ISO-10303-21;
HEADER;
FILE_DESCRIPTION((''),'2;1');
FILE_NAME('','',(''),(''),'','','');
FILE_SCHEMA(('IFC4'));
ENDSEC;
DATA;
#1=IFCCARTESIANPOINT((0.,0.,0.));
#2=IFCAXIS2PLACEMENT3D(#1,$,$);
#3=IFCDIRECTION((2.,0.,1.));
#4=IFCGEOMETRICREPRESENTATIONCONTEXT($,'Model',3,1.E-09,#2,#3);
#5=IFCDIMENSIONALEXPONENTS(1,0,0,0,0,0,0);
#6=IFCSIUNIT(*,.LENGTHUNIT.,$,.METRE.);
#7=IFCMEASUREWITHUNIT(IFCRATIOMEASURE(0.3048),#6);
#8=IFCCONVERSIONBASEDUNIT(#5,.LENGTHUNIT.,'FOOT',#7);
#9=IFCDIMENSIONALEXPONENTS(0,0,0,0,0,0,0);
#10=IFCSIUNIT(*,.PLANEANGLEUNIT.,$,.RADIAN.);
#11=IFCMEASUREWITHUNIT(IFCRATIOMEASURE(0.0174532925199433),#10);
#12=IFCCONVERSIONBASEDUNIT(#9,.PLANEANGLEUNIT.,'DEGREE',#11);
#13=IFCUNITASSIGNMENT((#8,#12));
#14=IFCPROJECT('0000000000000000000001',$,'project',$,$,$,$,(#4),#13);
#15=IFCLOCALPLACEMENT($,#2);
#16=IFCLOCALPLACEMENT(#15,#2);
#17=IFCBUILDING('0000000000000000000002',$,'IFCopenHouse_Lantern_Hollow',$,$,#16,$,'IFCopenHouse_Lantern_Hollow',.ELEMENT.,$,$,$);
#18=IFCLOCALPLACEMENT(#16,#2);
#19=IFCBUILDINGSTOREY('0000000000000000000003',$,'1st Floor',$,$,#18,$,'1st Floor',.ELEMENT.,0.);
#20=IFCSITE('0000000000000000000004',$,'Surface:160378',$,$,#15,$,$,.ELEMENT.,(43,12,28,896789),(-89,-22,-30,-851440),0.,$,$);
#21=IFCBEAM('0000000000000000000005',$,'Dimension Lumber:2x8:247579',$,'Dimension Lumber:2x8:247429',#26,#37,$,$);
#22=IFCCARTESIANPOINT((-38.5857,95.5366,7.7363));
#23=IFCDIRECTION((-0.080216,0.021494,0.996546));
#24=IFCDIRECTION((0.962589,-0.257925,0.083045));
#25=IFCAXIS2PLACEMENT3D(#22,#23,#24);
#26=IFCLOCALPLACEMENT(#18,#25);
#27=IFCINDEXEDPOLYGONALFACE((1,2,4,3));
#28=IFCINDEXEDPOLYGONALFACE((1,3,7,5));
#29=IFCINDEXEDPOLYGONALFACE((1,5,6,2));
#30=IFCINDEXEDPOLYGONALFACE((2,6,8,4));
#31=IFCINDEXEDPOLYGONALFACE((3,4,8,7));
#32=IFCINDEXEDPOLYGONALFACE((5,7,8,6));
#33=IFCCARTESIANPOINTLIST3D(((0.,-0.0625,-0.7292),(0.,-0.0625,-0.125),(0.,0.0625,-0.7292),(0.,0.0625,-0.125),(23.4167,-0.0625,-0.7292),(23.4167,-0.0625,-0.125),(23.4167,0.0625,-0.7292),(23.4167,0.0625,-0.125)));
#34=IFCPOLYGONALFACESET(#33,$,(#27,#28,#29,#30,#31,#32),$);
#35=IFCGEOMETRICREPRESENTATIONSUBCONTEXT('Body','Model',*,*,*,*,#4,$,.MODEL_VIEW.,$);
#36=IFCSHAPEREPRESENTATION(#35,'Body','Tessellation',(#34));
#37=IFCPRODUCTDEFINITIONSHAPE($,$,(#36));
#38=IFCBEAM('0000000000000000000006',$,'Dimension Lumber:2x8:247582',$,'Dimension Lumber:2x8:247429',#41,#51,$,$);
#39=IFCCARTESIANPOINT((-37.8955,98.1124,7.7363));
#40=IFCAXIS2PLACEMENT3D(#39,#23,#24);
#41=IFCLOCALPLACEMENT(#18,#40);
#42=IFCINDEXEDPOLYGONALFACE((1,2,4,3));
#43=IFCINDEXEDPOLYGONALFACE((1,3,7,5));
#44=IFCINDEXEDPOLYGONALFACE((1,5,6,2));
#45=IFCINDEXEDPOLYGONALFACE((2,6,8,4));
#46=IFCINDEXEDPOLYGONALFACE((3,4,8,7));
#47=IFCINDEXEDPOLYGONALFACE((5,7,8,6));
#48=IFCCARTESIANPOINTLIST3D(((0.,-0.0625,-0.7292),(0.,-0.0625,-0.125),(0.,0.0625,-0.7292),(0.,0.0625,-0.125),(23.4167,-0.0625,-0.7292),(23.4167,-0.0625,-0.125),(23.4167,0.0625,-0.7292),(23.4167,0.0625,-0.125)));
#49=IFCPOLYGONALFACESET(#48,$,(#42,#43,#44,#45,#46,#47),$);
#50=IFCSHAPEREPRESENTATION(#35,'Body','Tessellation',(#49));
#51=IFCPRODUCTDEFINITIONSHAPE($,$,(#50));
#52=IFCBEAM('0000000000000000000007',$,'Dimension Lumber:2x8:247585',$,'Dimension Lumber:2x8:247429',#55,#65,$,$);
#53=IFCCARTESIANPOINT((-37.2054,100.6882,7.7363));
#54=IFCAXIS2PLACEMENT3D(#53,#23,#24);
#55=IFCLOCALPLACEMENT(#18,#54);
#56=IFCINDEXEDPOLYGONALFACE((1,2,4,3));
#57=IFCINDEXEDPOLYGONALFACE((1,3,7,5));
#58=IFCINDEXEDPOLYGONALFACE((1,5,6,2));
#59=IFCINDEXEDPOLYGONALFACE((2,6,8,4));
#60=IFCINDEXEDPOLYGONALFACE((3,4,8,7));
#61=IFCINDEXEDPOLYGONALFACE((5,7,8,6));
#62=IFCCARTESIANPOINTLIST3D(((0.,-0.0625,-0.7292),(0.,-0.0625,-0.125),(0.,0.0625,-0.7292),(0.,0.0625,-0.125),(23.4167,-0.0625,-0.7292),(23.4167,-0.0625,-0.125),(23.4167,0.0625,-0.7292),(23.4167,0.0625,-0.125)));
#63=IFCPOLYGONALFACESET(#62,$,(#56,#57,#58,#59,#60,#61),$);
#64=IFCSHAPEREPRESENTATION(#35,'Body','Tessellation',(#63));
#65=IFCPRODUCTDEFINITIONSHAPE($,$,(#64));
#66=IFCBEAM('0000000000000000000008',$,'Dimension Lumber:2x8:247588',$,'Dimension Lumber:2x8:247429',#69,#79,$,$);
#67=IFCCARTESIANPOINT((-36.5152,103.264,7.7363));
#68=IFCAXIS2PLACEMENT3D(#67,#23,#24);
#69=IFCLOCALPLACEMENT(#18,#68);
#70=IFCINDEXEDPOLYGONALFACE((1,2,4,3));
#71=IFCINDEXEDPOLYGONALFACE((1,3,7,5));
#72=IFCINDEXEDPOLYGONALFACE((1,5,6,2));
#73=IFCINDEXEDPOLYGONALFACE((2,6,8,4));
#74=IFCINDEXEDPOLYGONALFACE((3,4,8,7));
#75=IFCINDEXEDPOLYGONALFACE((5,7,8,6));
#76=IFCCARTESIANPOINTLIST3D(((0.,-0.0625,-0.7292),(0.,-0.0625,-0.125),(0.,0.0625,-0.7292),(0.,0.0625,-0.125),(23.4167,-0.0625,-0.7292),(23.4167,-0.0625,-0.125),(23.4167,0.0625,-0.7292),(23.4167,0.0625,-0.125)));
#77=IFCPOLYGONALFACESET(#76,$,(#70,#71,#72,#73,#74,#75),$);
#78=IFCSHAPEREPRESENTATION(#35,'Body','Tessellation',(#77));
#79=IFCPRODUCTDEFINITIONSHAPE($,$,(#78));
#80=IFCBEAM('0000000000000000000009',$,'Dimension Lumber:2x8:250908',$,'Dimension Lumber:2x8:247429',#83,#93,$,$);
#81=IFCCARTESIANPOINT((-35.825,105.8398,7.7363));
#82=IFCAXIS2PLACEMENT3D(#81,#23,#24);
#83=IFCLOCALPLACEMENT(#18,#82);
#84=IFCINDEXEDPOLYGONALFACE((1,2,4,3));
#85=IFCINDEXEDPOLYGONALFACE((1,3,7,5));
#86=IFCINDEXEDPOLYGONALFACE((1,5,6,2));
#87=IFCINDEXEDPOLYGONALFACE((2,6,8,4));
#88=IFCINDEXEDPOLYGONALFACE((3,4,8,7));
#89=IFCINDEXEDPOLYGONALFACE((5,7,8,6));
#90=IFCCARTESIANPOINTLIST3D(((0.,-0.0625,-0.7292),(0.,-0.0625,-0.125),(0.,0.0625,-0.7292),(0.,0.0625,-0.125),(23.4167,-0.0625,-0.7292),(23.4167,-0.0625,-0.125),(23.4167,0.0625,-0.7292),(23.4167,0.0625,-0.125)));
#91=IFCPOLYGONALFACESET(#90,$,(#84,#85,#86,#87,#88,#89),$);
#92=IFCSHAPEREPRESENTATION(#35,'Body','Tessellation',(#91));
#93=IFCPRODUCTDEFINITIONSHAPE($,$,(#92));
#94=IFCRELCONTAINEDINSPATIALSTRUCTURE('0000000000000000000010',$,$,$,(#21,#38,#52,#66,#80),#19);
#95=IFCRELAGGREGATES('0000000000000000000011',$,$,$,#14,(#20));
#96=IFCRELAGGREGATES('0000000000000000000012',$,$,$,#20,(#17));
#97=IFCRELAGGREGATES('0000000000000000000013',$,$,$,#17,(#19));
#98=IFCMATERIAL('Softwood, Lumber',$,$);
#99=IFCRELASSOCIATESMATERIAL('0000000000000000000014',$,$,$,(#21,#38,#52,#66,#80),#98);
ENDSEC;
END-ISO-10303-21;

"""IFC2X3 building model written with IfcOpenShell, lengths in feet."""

from ifc_helpers import new_model, entity, si_unit, converted_unit, direction, frame, frame_2d, origin, place, context, subcontext, project, spatial, rectangle, extrude, material, element, save


model = new_model("IFC2X3")

# Units and contexts
model_context = context("Model", 3, precision=1e-09, world=origin(), true_north=direction((2.0, 0.0, 1.0)))
body_context = subcontext(model_context, "Body", "Model", "MODEL_VIEW")
ifc_project = project(units=[converted_unit("LENGTHUNIT", "FOOT", entity("IfcRatioMeasure", 0.3048), si_unit("LENGTHUNIT", "METRE"), dimensions=[1, 0, 0, 0, 0, 0, 0]), converted_unit("PLANEANGLEUNIT", "DEGREE", entity("IfcRatioMeasure", 0.0174532925199433), si_unit("PLANEANGLEUNIT", "RADIAN"), dimensions=[0, 0, 0, 0, 0, 0, 0])], contexts=[model_context])

# Site, building, storey
site_placement = place(None, origin())
site = spatial("IfcSite", under=ifc_project, at=site_placement, Name="Surface:160378", CompositionType="ELEMENT", RefLatitude=(43, 12, 28, 896789), RefLongitude=(-89, -22, -30, -851440), RefElevation=0.0)
building_placement = place(site_placement, origin())
building = spatial("IfcBuilding", under=site, at=building_placement, Name="IFCopenHouse_Lantern_Hollow", LongName="IFCopenHouse_Lantern_Hollow", CompositionType="ELEMENT")
storey_placement = place(building_placement, origin())
storey = spatial("IfcBuildingStorey", under=building, at=storey_placement, Name="1st Floor", LongName="1st Floor", CompositionType="ELEMENT", Elevation=0.0)

# Beams
ifc_material_1 = material(Name="Softwood, Lumber")
beam_1_placement = place(storey_placement, frame((-38.5857, 95.5366, 7.7363), z_axis=(-0.080216, 0.021494, 0.996546), x_axis=(0.962589, -0.257925, 0.083045)))
element("IfcBeam", 1, at=beam_1_placement, inside=storey, material=ifc_material_1, Name="Dimension Lumber:2x8:247579", ObjectType="Dimension Lumber:2x8:247429", context=body_context, shape_type="SweptSolid", body=[
    extrude(rectangle(XDim=0.6042, YDim=0.125, at=frame_2d((0.0, 0.0), x_axis=(1.0, 0.0))), frame((0.0, 0.0, -0.4271), z_axis=(1.0, 0.0, 0.0), x_axis=(0.0, 0.0, -1.0)), (0.0, 0.0, 1.0), 23.4167),
])
beam_2_placement = place(storey_placement, frame((-37.8955, 98.1124, 7.7363), z_axis=(-0.080216, 0.021494, 0.996546), x_axis=(0.962589, -0.257925, 0.083045)))
element("IfcBeam", 2, at=beam_2_placement, inside=storey, material=ifc_material_1, Name="Dimension Lumber:2x8:247582", ObjectType="Dimension Lumber:2x8:247429", context=body_context, shape_type="SweptSolid", body=[
    extrude(rectangle(XDim=0.6042, YDim=0.125, at=frame_2d((0.0, 0.0), x_axis=(1.0, 0.0))), frame((0.0, 0.0, -0.4271), z_axis=(1.0, 0.0, 0.0), x_axis=(0.0, 0.0, -1.0)), (0.0, 0.0, 1.0), 23.4167),
])
for number, where, z_axis, x_axis, name in (
    (3, (-37.2054, 100.6882, 7.7363), (-0.080216, 0.021494, 0.996546), (0.962589, -0.257925, 0.083045), "Dimension Lumber:2x8:247585"),
    (4, (-36.5152, 103.264, 7.7363), (-0.080216, 0.021494, 0.996546), (0.962589, -0.257925, 0.083045), "Dimension Lumber:2x8:247588"),
):
    element("IfcBeam", number, at=place(storey_placement, frame(where, z_axis=z_axis, x_axis=x_axis)), inside=storey, material=ifc_material_1, Name=name, ObjectType="Dimension Lumber:2x8:247429", context=body_context, shape_type="SweptSolid", body=[
        extrude(rectangle(XDim=0.6042, YDim=0.125, at=frame_2d((0.0, 0.0), x_axis=(1.0, 0.0))), frame((0.0, 0.0, -0.4271), z_axis=(1.0, 0.0, 0.0), x_axis=(0.0, 0.0, -1.0)), (0.0, 0.0, 1.0), 23.4167),
    ])
beam_3_placement = place(storey_placement, frame((-35.825, 105.8398, 7.7363), z_axis=(-0.080216, 0.021494, 0.996546), x_axis=(0.962589, -0.257925, 0.083045)))
element("IfcBeam", 5, at=beam_3_placement, inside=storey, material=ifc_material_1, Name="Dimension Lumber:2x8:250908", ObjectType="Dimension Lumber:2x8:247429", context=body_context, shape_type="SweptSolid", body=[
    extrude(rectangle(XDim=0.6042, YDim=0.125, at=frame_2d((0.0, 0.0), x_axis=(1.0, 0.0))), frame((0.0, 0.0, -0.4271), z_axis=(1.0, 0.0, 0.0), x_axis=(0.0, 0.0, -1.0)), (0.0, 0.0, 1.0), 23.4167),
])

save(model, "model.ifc")
